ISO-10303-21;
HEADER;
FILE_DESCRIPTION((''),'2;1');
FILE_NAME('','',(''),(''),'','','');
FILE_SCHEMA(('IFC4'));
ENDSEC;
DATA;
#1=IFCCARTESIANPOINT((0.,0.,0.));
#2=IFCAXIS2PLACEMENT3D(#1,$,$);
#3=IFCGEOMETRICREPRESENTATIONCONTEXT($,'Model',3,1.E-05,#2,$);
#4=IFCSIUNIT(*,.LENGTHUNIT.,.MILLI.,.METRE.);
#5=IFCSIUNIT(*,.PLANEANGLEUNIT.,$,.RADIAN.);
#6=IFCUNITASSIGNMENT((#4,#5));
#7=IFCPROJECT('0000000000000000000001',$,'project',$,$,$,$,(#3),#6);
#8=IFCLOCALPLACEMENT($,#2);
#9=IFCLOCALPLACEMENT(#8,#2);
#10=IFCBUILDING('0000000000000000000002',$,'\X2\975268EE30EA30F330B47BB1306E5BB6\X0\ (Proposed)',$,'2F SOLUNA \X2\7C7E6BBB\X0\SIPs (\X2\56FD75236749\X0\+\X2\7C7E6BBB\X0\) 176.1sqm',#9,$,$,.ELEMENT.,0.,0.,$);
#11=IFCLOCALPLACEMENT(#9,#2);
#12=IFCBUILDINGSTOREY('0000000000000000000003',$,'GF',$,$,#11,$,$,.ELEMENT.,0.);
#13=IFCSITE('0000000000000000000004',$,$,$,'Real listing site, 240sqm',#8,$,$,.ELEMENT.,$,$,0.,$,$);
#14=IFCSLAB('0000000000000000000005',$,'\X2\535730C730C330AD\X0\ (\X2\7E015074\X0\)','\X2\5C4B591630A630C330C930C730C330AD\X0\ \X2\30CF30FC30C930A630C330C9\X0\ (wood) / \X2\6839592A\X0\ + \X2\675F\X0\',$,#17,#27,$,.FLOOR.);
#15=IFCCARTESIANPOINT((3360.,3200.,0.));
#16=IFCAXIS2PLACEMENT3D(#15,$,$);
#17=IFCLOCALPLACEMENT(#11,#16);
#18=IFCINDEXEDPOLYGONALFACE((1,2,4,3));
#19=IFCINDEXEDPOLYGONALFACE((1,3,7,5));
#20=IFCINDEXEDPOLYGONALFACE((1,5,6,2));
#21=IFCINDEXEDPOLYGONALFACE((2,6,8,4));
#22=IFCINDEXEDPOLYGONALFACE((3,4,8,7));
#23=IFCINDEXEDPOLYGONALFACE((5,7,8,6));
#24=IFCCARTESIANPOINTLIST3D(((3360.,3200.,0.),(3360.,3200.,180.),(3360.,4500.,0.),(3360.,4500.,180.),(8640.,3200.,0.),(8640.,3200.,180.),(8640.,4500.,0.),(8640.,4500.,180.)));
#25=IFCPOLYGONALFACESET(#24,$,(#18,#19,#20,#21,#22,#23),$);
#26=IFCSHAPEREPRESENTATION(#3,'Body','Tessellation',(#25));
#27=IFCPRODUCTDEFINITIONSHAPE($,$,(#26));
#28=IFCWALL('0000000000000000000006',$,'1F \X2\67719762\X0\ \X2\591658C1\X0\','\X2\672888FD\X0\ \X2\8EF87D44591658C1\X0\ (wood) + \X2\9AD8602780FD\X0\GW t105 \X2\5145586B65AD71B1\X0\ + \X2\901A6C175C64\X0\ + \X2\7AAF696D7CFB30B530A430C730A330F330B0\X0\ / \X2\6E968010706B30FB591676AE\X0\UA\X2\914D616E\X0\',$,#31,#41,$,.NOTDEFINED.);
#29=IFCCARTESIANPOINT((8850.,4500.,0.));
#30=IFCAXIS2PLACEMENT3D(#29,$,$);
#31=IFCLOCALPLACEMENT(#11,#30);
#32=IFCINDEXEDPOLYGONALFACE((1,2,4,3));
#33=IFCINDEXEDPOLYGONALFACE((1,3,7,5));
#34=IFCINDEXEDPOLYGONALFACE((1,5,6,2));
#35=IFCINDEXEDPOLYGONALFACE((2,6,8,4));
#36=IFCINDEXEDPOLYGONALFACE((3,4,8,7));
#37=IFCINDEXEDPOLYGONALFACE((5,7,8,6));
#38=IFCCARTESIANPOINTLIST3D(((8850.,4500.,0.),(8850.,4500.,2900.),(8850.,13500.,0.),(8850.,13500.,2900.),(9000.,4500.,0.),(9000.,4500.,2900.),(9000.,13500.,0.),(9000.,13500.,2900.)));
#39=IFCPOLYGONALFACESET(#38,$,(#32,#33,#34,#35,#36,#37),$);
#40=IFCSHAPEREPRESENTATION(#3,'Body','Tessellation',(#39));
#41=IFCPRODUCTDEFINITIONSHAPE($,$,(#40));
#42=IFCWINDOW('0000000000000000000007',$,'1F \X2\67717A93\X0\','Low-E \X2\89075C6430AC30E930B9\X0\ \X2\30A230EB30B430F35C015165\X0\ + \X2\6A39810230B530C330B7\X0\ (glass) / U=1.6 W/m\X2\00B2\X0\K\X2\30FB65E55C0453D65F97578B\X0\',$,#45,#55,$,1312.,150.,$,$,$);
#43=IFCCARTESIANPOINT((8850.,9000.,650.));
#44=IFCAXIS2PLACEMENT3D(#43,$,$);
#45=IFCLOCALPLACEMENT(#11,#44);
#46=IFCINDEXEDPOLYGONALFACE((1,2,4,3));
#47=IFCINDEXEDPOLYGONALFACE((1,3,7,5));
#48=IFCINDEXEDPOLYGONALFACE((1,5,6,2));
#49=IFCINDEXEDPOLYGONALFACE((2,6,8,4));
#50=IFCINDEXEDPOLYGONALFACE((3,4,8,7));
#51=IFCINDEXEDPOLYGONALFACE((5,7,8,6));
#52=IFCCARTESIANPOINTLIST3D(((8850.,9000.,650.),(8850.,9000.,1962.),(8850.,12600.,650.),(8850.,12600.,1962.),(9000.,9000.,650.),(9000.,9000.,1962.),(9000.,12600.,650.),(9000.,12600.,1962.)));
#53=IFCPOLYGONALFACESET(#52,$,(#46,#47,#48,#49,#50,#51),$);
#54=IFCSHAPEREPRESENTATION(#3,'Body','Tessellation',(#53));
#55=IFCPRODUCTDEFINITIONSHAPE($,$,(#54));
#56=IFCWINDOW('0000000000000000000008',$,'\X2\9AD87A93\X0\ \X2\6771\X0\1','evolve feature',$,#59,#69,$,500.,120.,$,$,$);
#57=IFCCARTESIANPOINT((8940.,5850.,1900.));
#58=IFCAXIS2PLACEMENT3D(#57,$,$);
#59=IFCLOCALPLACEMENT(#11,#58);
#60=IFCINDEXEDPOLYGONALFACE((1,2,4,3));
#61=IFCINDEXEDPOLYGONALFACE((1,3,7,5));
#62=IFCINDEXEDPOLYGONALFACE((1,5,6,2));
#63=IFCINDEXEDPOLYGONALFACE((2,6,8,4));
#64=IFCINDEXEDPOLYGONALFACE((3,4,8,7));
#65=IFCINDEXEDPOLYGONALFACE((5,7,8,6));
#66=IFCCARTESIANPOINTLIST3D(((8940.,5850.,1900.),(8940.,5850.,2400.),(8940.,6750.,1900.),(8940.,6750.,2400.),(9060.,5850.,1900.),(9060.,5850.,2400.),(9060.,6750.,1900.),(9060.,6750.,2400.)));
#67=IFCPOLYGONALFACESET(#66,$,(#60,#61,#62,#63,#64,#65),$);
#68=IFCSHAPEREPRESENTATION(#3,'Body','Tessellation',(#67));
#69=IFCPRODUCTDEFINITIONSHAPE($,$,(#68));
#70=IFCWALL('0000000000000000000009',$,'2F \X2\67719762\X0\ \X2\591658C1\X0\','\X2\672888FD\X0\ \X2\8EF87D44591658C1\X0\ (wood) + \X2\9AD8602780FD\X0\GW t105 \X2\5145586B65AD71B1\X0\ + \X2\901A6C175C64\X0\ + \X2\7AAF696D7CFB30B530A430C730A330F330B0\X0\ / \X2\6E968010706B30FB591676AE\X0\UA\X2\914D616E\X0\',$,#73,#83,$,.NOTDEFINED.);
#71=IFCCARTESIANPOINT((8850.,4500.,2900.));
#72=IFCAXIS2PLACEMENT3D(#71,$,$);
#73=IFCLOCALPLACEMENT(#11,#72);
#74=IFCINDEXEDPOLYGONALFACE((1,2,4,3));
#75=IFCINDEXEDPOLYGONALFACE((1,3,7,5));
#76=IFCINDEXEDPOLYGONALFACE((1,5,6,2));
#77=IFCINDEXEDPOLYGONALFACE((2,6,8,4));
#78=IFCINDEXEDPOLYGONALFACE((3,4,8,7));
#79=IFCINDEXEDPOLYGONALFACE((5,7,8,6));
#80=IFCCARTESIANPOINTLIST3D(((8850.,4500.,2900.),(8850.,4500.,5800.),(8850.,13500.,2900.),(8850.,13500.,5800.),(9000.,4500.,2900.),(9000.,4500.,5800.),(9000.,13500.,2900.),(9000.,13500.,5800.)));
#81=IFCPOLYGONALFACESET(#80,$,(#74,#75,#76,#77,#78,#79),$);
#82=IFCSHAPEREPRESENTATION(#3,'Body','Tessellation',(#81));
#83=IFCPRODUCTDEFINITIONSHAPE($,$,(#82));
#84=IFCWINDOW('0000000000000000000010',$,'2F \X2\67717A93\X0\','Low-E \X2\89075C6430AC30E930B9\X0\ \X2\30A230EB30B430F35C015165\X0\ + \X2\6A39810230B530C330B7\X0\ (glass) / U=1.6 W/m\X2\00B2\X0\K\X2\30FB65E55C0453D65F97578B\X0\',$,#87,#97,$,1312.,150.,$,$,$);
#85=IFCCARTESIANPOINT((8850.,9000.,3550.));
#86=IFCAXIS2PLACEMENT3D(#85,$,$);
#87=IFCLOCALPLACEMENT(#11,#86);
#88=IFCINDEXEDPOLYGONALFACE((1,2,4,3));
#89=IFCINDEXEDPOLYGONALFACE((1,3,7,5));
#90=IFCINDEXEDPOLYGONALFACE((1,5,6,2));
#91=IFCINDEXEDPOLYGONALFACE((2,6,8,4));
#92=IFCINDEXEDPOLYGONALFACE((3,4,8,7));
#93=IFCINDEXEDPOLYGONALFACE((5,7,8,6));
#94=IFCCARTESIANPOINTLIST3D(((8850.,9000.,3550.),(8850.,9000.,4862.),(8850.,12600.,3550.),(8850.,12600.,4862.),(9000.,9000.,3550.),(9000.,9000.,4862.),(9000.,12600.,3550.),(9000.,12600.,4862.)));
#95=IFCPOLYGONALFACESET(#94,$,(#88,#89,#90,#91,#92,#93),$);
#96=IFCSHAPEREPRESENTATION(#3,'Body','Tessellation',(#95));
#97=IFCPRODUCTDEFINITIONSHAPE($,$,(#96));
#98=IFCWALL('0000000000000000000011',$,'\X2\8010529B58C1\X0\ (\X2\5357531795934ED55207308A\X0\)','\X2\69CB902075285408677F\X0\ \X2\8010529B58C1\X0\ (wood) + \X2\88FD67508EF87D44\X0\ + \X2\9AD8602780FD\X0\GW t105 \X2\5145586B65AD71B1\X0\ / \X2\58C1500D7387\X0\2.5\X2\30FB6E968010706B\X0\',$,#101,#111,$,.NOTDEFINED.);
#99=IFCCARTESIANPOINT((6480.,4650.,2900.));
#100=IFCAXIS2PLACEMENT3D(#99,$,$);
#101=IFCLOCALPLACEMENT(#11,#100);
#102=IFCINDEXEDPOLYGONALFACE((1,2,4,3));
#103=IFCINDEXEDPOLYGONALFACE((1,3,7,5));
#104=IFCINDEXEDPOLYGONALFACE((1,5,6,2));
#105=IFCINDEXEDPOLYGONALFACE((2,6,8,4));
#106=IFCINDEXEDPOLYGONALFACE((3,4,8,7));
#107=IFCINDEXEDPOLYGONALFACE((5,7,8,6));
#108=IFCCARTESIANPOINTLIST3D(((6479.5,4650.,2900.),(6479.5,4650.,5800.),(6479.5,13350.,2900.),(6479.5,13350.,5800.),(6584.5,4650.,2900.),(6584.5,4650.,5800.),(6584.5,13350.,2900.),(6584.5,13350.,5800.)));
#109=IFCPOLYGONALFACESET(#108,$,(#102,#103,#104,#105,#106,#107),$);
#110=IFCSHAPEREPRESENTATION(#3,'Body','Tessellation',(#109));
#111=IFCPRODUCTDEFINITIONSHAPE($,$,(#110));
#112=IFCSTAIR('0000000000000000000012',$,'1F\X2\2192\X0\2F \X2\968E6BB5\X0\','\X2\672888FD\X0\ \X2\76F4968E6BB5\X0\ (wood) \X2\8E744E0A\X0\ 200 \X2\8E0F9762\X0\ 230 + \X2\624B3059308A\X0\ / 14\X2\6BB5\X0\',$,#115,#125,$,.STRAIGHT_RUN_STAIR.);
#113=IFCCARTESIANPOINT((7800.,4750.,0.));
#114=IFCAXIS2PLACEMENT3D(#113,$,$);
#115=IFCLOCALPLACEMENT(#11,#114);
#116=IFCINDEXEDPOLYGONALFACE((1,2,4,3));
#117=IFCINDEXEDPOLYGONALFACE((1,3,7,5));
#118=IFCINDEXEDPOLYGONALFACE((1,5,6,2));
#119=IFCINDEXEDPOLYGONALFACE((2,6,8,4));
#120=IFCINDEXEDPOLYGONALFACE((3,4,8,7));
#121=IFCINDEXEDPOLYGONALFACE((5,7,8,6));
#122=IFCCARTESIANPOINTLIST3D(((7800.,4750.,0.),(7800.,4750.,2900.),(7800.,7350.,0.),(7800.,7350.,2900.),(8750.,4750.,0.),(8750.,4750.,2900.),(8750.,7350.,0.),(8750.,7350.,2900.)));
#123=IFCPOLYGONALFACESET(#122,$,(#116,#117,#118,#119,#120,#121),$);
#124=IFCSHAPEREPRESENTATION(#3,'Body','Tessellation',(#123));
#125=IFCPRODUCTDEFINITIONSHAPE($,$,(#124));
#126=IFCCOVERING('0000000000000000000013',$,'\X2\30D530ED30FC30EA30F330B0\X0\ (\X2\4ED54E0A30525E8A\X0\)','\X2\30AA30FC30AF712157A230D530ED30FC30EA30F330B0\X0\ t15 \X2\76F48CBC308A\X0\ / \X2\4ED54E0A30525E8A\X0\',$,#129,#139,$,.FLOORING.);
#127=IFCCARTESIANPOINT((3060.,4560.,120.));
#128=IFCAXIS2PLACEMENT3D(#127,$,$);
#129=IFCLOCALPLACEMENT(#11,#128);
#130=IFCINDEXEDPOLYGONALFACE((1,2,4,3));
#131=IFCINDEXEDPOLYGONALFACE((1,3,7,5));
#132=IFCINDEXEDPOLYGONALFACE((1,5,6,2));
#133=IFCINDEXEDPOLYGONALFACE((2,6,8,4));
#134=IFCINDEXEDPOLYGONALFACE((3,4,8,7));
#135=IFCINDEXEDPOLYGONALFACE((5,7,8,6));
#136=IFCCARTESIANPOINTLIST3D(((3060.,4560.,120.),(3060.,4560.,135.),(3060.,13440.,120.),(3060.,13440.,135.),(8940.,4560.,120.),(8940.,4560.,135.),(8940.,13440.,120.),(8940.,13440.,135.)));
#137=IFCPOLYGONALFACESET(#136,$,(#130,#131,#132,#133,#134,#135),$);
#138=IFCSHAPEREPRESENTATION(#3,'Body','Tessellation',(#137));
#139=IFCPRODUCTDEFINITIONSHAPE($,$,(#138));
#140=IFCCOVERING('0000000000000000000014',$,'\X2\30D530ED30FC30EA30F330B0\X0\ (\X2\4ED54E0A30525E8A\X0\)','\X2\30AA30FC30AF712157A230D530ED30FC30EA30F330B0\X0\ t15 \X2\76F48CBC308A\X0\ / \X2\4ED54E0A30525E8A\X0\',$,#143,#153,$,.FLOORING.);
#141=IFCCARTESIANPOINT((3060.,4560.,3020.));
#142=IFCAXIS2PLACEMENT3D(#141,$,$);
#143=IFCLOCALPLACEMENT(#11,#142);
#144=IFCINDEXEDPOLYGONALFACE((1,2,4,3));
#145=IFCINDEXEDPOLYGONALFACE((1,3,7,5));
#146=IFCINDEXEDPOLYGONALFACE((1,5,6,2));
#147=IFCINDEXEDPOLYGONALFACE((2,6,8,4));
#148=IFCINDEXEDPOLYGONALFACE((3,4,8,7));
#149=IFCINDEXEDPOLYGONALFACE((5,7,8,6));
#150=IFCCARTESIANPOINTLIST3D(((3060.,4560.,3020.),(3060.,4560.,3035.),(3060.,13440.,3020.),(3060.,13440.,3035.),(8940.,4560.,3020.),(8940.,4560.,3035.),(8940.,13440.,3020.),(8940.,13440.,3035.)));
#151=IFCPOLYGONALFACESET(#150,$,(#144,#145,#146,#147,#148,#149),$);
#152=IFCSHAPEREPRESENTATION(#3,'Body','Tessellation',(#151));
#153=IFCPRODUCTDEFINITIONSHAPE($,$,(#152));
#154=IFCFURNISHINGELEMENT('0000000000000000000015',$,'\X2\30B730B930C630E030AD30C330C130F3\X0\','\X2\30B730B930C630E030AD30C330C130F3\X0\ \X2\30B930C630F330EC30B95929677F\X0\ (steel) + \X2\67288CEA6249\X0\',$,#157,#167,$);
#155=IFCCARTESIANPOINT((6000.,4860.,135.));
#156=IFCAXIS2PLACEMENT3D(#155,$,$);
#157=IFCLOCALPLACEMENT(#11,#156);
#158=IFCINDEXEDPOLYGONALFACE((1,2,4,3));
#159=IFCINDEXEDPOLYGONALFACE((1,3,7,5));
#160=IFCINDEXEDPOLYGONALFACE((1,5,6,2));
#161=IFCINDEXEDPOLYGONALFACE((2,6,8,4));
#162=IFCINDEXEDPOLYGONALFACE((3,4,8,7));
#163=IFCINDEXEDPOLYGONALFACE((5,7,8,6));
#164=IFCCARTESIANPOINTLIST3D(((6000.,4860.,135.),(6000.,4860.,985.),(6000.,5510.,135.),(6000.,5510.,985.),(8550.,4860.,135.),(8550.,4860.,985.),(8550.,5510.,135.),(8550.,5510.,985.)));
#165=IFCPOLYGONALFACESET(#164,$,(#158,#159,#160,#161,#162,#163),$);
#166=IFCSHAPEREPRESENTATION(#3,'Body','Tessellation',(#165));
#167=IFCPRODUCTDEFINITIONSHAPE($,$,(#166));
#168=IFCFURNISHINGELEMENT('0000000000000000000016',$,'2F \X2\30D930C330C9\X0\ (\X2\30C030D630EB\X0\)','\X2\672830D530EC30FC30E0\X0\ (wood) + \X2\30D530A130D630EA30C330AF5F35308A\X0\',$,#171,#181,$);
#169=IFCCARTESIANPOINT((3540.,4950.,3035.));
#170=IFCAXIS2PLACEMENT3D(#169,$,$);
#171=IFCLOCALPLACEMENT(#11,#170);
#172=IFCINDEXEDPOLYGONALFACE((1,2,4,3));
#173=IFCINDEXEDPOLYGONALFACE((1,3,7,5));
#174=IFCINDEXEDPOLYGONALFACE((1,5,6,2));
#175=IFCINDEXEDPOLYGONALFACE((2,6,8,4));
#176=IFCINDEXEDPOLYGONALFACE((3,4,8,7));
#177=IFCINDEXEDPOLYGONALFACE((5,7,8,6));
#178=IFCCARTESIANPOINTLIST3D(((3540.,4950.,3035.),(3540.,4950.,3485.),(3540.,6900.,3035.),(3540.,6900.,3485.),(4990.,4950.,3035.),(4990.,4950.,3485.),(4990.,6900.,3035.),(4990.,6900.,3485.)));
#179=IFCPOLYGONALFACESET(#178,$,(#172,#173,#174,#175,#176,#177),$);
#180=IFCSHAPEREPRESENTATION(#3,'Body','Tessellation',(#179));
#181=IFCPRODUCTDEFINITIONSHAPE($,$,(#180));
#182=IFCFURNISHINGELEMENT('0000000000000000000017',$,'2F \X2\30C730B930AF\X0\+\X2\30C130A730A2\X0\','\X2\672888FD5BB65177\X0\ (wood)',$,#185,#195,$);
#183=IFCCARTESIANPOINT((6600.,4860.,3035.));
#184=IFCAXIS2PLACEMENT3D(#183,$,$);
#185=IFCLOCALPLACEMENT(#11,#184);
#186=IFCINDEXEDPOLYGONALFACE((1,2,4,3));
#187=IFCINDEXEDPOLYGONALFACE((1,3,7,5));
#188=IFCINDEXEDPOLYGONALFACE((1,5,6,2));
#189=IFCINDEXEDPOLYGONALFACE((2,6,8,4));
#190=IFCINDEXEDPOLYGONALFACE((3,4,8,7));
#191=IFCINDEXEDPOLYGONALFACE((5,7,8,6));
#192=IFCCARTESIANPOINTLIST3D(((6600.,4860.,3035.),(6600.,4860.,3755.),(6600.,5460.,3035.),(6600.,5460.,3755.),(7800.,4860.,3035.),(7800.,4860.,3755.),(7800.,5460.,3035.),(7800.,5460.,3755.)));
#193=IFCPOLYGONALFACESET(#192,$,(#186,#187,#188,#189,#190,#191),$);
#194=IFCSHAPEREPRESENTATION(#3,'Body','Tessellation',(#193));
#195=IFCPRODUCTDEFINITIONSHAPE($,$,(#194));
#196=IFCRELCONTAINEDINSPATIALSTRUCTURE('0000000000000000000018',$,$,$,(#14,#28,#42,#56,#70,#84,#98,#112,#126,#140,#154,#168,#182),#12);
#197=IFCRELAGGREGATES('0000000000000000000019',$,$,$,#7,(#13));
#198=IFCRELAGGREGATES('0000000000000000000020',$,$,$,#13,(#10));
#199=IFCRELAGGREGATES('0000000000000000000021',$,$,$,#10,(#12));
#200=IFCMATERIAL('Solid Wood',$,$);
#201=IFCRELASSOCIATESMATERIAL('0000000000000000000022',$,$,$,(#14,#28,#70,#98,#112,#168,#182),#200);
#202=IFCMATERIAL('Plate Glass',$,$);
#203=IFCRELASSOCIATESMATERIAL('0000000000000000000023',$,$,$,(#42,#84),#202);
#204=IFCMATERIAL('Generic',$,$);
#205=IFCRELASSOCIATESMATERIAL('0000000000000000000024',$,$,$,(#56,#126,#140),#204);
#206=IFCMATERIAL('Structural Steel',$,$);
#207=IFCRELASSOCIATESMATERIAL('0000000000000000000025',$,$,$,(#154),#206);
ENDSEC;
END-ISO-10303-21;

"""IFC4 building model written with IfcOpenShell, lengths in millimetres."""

from ifc_helpers import new_model, si_unit, frame, frame_2d, origin, place, context, project, spatial, rectangle, extrude, material, element, fill, save


model = new_model("IFC4")

# Units and contexts
model_context = context("Model", 3, precision=1e-05, world=origin())
ifc_project = project(units=[si_unit("LENGTHUNIT", "METRE", prefix="MILLI"), si_unit("PLANEANGLEUNIT", "RADIAN")], contexts=[model_context])

# Site, building, storey
site_placement = place(None, origin())
site = spatial("IfcSite", under=ifc_project, at=site_placement, ObjectType="Real listing site, 240sqm", CompositionType="ELEMENT", RefElevation=0.0)
building_placement = place(site_placement, origin())
building = spatial("IfcBuilding", under=site, at=building_placement, Name="青森リンゴ箱の家 (Proposed)", ObjectType="2F SOLUNA 籾殻SIPs (国産杉+籾殻) 176.1sqm", CompositionType="ELEMENT", ElevationOfRefHeight=0.0, ElevationOfTerrain=0.0)
storey_placement = place(building_placement, origin())
storey = spatial("IfcBuildingStorey", under=building, at=storey_placement, Name="GF", CompositionType="ELEMENT", Elevation=0.0)

# Slab
ifc_material_1 = material(Name="Solid Wood")
slab_placement = place(storey_placement, frame((3360.0, 3200.0, 0.0)))
element("IfcSlab", 1, at=slab_placement, inside=storey, material=ifc_material_1, Name="南デッキ (縁側)", Description="屋外ウッドデッキ ハードウッド (wood) / 根太 + 束", PredefinedType="FLOOR", context=model_context, shape_type="SweptSolid", body=[
    extrude(rectangle(XDim=5280.0, YDim=1300.0, at=frame_2d((2640.0, 650.0))), frame((3360.0, 3200.0, 0.0)), (0.0, 0.0, 1.0), 180.0),
])

# Wall, openings, windows
wall_1_placement = place(storey_placement, frame((8850.0, 4500.0, 0.0)))
wall_1 = element("IfcWall", 2, at=wall_1_placement, inside=storey, material=ifc_material_1, Name="1F 東面 外壁", Description="木製 軸組外壁 (wood) + 高性能GW t105 充填断熱 + 通気層 + 窯業系サイディング / 準耐火・外皮UA配慮", PredefinedType="NOTDEFINED", context=model_context, shape_type="SweptSolid", body=[
    extrude(rectangle(XDim=150.0, YDim=9000.0, at=frame_2d((75.0, 4500.0))), frame((8850.0, 4500.0, 0.0)), (0.0, 0.0, 1.0), 2900.0),
])
opening_1_placement = place(storey_placement, frame((8850.0, 9000.0, 650.0)))
opening_1 = element("IfcOpeningElement", 3, at=opening_1_placement, cuts=wall_1, PredefinedType="NOTDEFINED", context=model_context, shape_type="SweptSolid", body=[
    extrude(rectangle(XDim=150.0, YDim=3600.0, at=frame_2d((75.0, 1800.0))), frame((8850.0, 9000.0, 650.0)), (0.0, 0.0, 1.0), 1312.0),
])
opening_2_placement = place(storey_placement, frame((8940.0, 5850.0, 1900.0)))
opening_2 = element("IfcOpeningElement", 4, at=opening_2_placement, cuts=wall_1, PredefinedType="NOTDEFINED", context=model_context, shape_type="SweptSolid", body=[
    extrude(rectangle(XDim=120.0, YDim=900.0, at=frame_2d((60.0, 450.0))), frame((8940.0, 5850.0, 1900.0)), (0.0, 0.0, 1.0), 500.0),
])
ifc_material_2 = material(Name="Plate Glass")
window_1_placement = place(storey_placement, frame((8850.0, 9000.0, 650.0)))
window_1 = element("IfcWindow", 5, at=window_1_placement, inside=storey, material=ifc_material_2, Name="1F 東窓", Description="Low-E 複層ガラス アルゴン封入 + 樹脂サッシ (glass) / U=1.6 W/m²K・日射取得型", OverallHeight=1312.0, OverallWidth=150.0, context=model_context, shape_type="SweptSolid", body=[
    extrude(rectangle(XDim=150.0, YDim=3600.0, at=frame_2d((75.0, 1800.0))), frame((8850.0, 9000.0, 650.0)), (0.0, 0.0, 1.0), 1312.0),
])
fill(opening_1, window_1)
ifc_material_3 = material(Name="Generic")
window_2_placement = place(storey_placement, frame((8940.0, 5850.0, 1900.0)))
window_2 = element("IfcWindow", 6, at=window_2_placement, inside=storey, material=ifc_material_3, Name="高窓 東1", Description="evolve feature", OverallHeight=500.0, OverallWidth=120.0, context=model_context, shape_type="SweptSolid", body=[
    extrude(rectangle(XDim=120.0, YDim=900.0, at=frame_2d((60.0, 450.0))), frame((8940.0, 5850.0, 1900.0)), (0.0, 0.0, 1.0), 500.0),
])
fill(opening_2, window_2)

# Wall, opening, window
wall_2_placement = place(storey_placement, frame((8850.0, 4500.0, 2900.0)))
wall_2 = element("IfcWall", 7, at=wall_2_placement, inside=storey, material=ifc_material_1, Name="2F 東面 外壁", Description="木製 軸組外壁 (wood) + 高性能GW t105 充填断熱 + 通気層 + 窯業系サイディング / 準耐火・外皮UA配慮", PredefinedType="NOTDEFINED", context=model_context, shape_type="SweptSolid", body=[
    extrude(rectangle(XDim=150.0, YDim=9000.0, at=frame_2d((75.0, 4500.0))), frame((8850.0, 4500.0, 2900.0)), (0.0, 0.0, 1.0), 2900.0),
])
opening_3_placement = place(storey_placement, frame((8850.0, 9000.0, 3550.0)))
opening_3 = element("IfcOpeningElement", 8, at=opening_3_placement, cuts=wall_2, PredefinedType="NOTDEFINED", context=model_context, shape_type="SweptSolid", body=[
    extrude(rectangle(XDim=150.0, YDim=3600.0, at=frame_2d((75.0, 1800.0))), frame((8850.0, 9000.0, 3550.0)), (0.0, 0.0, 1.0), 1312.0),
])
window_3_placement = place(storey_placement, frame((8850.0, 9000.0, 3550.0)))
window_3 = element("IfcWindow", 9, at=window_3_placement, inside=storey, material=ifc_material_2, Name="2F 東窓", Description="Low-E 複層ガラス アルゴン封入 + 樹脂サッシ (glass) / U=1.6 W/m²K・日射取得型", OverallHeight=1312.0, OverallWidth=150.0, context=model_context, shape_type="SweptSolid", body=[
    extrude(rectangle(XDim=150.0, YDim=3600.0, at=frame_2d((75.0, 1800.0))), frame((8850.0, 9000.0, 3550.0)), (0.0, 0.0, 1.0), 1312.0),
])
fill(opening_3, window_3)

# Wall
wall_3_placement = place(storey_placement, frame((6480.0, 4650.0, 2900.0)))
element("IfcWall", 10, at=wall_3_placement, inside=storey, material=ifc_material_1, Name="耐力壁 (南北間仕切り)", Description="構造用合板 耐力壁 (wood) + 製材軸組 + 高性能GW t105 充填断熱 / 壁倍率2.5・準耐火", PredefinedType="NOTDEFINED", context=model_context, shape_type="SweptSolid", body=[
    extrude(rectangle(XDim=105.0, YDim=8700.0, at=frame_2d((52.0, 4350.0))), frame((6480.0, 4650.0, 2900.0)), (0.0, 0.0, 1.0), 2900.0),
])

# Stair
stair_placement = place(storey_placement, frame((7800.0, 4750.0, 0.0)))
element("IfcStair", 11, at=stair_placement, inside=storey, material=ifc_material_1, Name="1F→2F 階段", Description="木製 直階段 (wood) 蹴上 200 踏面 230 + 手すり / 14段", PredefinedType="STRAIGHT_RUN_STAIR", context=model_context, shape_type="SweptSolid", body=[
    extrude(rectangle(XDim=950.0, YDim=2600.0, at=frame_2d((475.0, 1300.0))), frame((7800.0, 4750.0, 0.0)), (0.0, 0.0, 1.0), 2900.0),
])

# Coverings
covering_1_placement = place(storey_placement, frame((3060.0, 4560.0, 120.0)))
element("IfcCovering", 12, at=covering_1_placement, inside=storey, material=ifc_material_3, Name="フローリング (仕上げ床)", Description="オーク無垢フローリング t15 直貼り / 仕上げ床", PredefinedType="FLOORING", context=model_context, shape_type="SweptSolid", body=[
    extrude(rectangle(XDim=5880.0, YDim=8880.0, at=frame_2d((2940.0, 4440.0))), frame((3060.0, 4560.0, 120.0)), (0.0, 0.0, 1.0), 15.0),
])
covering_2_placement = place(storey_placement, frame((3060.0, 4560.0, 3020.0)))
element("IfcCovering", 13, at=covering_2_placement, inside=storey, material=ifc_material_3, Name="フローリング (仕上げ床)", Description="オーク無垢フローリング t15 直貼り / 仕上げ床", PredefinedType="FLOORING", context=model_context, shape_type="SweptSolid", body=[
    extrude(rectangle(XDim=5880.0, YDim=8880.0, at=frame_2d((2940.0, 4440.0))), frame((3060.0, 4560.0, 3020.0)), (0.0, 0.0, 1.0), 15.0),
])

# Furnishing elements
ifc_material_4 = material(Name="Structural Steel")
furnishing_1_placement = place(storey_placement, frame((6000.0, 4860.0, 135.0)))
element("IfcFurnishingElement", 14, at=furnishing_1_placement, inside=storey, material=ifc_material_4, Name="システムキッチン", Description="システムキッチン ステンレス天板 (steel) + 木質扉", context=model_context, shape_type="SweptSolid", body=[
    extrude(rectangle(XDim=2550.0, YDim=650.0, at=frame_2d((1275.0, 325.0))), frame((6000.0, 4860.0, 135.0)), (0.0, 0.0, 1.0), 850.0),
])
furnishing_2_placement = place(storey_placement, frame((3540.0, 4950.0, 3035.0)))
element("IfcFurnishingElement", 15, at=furnishing_2_placement, inside=storey, material=ifc_material_1, Name="2F ベッド (ダブル)", Description="木フレーム (wood) + ファブリック張り", context=model_context, shape_type="SweptSolid", body=[
    extrude(rectangle(XDim=1450.0, YDim=1950.0, at=frame_2d((725.0, 975.0))), frame((3540.0, 4950.0, 3035.0)), (0.0, 0.0, 1.0), 450.0),
])
furnishing_3_placement = place(storey_placement, frame((6600.0, 4860.0, 3035.0)))
element("IfcFurnishingElement", 16, at=furnishing_3_placement, inside=storey, material=ifc_material_1, Name="2F デスク+チェア", Description="木製家具 (wood)", context=model_context, shape_type="SweptSolid", body=[
    extrude(rectangle(XDim=1200.0, YDim=600.0, at=frame_2d((600.0, 300.0))), frame((6600.0, 4860.0, 3035.0)), (0.0, 0.0, 1.0), 720.0),
])

save(model, "model.ifc")
